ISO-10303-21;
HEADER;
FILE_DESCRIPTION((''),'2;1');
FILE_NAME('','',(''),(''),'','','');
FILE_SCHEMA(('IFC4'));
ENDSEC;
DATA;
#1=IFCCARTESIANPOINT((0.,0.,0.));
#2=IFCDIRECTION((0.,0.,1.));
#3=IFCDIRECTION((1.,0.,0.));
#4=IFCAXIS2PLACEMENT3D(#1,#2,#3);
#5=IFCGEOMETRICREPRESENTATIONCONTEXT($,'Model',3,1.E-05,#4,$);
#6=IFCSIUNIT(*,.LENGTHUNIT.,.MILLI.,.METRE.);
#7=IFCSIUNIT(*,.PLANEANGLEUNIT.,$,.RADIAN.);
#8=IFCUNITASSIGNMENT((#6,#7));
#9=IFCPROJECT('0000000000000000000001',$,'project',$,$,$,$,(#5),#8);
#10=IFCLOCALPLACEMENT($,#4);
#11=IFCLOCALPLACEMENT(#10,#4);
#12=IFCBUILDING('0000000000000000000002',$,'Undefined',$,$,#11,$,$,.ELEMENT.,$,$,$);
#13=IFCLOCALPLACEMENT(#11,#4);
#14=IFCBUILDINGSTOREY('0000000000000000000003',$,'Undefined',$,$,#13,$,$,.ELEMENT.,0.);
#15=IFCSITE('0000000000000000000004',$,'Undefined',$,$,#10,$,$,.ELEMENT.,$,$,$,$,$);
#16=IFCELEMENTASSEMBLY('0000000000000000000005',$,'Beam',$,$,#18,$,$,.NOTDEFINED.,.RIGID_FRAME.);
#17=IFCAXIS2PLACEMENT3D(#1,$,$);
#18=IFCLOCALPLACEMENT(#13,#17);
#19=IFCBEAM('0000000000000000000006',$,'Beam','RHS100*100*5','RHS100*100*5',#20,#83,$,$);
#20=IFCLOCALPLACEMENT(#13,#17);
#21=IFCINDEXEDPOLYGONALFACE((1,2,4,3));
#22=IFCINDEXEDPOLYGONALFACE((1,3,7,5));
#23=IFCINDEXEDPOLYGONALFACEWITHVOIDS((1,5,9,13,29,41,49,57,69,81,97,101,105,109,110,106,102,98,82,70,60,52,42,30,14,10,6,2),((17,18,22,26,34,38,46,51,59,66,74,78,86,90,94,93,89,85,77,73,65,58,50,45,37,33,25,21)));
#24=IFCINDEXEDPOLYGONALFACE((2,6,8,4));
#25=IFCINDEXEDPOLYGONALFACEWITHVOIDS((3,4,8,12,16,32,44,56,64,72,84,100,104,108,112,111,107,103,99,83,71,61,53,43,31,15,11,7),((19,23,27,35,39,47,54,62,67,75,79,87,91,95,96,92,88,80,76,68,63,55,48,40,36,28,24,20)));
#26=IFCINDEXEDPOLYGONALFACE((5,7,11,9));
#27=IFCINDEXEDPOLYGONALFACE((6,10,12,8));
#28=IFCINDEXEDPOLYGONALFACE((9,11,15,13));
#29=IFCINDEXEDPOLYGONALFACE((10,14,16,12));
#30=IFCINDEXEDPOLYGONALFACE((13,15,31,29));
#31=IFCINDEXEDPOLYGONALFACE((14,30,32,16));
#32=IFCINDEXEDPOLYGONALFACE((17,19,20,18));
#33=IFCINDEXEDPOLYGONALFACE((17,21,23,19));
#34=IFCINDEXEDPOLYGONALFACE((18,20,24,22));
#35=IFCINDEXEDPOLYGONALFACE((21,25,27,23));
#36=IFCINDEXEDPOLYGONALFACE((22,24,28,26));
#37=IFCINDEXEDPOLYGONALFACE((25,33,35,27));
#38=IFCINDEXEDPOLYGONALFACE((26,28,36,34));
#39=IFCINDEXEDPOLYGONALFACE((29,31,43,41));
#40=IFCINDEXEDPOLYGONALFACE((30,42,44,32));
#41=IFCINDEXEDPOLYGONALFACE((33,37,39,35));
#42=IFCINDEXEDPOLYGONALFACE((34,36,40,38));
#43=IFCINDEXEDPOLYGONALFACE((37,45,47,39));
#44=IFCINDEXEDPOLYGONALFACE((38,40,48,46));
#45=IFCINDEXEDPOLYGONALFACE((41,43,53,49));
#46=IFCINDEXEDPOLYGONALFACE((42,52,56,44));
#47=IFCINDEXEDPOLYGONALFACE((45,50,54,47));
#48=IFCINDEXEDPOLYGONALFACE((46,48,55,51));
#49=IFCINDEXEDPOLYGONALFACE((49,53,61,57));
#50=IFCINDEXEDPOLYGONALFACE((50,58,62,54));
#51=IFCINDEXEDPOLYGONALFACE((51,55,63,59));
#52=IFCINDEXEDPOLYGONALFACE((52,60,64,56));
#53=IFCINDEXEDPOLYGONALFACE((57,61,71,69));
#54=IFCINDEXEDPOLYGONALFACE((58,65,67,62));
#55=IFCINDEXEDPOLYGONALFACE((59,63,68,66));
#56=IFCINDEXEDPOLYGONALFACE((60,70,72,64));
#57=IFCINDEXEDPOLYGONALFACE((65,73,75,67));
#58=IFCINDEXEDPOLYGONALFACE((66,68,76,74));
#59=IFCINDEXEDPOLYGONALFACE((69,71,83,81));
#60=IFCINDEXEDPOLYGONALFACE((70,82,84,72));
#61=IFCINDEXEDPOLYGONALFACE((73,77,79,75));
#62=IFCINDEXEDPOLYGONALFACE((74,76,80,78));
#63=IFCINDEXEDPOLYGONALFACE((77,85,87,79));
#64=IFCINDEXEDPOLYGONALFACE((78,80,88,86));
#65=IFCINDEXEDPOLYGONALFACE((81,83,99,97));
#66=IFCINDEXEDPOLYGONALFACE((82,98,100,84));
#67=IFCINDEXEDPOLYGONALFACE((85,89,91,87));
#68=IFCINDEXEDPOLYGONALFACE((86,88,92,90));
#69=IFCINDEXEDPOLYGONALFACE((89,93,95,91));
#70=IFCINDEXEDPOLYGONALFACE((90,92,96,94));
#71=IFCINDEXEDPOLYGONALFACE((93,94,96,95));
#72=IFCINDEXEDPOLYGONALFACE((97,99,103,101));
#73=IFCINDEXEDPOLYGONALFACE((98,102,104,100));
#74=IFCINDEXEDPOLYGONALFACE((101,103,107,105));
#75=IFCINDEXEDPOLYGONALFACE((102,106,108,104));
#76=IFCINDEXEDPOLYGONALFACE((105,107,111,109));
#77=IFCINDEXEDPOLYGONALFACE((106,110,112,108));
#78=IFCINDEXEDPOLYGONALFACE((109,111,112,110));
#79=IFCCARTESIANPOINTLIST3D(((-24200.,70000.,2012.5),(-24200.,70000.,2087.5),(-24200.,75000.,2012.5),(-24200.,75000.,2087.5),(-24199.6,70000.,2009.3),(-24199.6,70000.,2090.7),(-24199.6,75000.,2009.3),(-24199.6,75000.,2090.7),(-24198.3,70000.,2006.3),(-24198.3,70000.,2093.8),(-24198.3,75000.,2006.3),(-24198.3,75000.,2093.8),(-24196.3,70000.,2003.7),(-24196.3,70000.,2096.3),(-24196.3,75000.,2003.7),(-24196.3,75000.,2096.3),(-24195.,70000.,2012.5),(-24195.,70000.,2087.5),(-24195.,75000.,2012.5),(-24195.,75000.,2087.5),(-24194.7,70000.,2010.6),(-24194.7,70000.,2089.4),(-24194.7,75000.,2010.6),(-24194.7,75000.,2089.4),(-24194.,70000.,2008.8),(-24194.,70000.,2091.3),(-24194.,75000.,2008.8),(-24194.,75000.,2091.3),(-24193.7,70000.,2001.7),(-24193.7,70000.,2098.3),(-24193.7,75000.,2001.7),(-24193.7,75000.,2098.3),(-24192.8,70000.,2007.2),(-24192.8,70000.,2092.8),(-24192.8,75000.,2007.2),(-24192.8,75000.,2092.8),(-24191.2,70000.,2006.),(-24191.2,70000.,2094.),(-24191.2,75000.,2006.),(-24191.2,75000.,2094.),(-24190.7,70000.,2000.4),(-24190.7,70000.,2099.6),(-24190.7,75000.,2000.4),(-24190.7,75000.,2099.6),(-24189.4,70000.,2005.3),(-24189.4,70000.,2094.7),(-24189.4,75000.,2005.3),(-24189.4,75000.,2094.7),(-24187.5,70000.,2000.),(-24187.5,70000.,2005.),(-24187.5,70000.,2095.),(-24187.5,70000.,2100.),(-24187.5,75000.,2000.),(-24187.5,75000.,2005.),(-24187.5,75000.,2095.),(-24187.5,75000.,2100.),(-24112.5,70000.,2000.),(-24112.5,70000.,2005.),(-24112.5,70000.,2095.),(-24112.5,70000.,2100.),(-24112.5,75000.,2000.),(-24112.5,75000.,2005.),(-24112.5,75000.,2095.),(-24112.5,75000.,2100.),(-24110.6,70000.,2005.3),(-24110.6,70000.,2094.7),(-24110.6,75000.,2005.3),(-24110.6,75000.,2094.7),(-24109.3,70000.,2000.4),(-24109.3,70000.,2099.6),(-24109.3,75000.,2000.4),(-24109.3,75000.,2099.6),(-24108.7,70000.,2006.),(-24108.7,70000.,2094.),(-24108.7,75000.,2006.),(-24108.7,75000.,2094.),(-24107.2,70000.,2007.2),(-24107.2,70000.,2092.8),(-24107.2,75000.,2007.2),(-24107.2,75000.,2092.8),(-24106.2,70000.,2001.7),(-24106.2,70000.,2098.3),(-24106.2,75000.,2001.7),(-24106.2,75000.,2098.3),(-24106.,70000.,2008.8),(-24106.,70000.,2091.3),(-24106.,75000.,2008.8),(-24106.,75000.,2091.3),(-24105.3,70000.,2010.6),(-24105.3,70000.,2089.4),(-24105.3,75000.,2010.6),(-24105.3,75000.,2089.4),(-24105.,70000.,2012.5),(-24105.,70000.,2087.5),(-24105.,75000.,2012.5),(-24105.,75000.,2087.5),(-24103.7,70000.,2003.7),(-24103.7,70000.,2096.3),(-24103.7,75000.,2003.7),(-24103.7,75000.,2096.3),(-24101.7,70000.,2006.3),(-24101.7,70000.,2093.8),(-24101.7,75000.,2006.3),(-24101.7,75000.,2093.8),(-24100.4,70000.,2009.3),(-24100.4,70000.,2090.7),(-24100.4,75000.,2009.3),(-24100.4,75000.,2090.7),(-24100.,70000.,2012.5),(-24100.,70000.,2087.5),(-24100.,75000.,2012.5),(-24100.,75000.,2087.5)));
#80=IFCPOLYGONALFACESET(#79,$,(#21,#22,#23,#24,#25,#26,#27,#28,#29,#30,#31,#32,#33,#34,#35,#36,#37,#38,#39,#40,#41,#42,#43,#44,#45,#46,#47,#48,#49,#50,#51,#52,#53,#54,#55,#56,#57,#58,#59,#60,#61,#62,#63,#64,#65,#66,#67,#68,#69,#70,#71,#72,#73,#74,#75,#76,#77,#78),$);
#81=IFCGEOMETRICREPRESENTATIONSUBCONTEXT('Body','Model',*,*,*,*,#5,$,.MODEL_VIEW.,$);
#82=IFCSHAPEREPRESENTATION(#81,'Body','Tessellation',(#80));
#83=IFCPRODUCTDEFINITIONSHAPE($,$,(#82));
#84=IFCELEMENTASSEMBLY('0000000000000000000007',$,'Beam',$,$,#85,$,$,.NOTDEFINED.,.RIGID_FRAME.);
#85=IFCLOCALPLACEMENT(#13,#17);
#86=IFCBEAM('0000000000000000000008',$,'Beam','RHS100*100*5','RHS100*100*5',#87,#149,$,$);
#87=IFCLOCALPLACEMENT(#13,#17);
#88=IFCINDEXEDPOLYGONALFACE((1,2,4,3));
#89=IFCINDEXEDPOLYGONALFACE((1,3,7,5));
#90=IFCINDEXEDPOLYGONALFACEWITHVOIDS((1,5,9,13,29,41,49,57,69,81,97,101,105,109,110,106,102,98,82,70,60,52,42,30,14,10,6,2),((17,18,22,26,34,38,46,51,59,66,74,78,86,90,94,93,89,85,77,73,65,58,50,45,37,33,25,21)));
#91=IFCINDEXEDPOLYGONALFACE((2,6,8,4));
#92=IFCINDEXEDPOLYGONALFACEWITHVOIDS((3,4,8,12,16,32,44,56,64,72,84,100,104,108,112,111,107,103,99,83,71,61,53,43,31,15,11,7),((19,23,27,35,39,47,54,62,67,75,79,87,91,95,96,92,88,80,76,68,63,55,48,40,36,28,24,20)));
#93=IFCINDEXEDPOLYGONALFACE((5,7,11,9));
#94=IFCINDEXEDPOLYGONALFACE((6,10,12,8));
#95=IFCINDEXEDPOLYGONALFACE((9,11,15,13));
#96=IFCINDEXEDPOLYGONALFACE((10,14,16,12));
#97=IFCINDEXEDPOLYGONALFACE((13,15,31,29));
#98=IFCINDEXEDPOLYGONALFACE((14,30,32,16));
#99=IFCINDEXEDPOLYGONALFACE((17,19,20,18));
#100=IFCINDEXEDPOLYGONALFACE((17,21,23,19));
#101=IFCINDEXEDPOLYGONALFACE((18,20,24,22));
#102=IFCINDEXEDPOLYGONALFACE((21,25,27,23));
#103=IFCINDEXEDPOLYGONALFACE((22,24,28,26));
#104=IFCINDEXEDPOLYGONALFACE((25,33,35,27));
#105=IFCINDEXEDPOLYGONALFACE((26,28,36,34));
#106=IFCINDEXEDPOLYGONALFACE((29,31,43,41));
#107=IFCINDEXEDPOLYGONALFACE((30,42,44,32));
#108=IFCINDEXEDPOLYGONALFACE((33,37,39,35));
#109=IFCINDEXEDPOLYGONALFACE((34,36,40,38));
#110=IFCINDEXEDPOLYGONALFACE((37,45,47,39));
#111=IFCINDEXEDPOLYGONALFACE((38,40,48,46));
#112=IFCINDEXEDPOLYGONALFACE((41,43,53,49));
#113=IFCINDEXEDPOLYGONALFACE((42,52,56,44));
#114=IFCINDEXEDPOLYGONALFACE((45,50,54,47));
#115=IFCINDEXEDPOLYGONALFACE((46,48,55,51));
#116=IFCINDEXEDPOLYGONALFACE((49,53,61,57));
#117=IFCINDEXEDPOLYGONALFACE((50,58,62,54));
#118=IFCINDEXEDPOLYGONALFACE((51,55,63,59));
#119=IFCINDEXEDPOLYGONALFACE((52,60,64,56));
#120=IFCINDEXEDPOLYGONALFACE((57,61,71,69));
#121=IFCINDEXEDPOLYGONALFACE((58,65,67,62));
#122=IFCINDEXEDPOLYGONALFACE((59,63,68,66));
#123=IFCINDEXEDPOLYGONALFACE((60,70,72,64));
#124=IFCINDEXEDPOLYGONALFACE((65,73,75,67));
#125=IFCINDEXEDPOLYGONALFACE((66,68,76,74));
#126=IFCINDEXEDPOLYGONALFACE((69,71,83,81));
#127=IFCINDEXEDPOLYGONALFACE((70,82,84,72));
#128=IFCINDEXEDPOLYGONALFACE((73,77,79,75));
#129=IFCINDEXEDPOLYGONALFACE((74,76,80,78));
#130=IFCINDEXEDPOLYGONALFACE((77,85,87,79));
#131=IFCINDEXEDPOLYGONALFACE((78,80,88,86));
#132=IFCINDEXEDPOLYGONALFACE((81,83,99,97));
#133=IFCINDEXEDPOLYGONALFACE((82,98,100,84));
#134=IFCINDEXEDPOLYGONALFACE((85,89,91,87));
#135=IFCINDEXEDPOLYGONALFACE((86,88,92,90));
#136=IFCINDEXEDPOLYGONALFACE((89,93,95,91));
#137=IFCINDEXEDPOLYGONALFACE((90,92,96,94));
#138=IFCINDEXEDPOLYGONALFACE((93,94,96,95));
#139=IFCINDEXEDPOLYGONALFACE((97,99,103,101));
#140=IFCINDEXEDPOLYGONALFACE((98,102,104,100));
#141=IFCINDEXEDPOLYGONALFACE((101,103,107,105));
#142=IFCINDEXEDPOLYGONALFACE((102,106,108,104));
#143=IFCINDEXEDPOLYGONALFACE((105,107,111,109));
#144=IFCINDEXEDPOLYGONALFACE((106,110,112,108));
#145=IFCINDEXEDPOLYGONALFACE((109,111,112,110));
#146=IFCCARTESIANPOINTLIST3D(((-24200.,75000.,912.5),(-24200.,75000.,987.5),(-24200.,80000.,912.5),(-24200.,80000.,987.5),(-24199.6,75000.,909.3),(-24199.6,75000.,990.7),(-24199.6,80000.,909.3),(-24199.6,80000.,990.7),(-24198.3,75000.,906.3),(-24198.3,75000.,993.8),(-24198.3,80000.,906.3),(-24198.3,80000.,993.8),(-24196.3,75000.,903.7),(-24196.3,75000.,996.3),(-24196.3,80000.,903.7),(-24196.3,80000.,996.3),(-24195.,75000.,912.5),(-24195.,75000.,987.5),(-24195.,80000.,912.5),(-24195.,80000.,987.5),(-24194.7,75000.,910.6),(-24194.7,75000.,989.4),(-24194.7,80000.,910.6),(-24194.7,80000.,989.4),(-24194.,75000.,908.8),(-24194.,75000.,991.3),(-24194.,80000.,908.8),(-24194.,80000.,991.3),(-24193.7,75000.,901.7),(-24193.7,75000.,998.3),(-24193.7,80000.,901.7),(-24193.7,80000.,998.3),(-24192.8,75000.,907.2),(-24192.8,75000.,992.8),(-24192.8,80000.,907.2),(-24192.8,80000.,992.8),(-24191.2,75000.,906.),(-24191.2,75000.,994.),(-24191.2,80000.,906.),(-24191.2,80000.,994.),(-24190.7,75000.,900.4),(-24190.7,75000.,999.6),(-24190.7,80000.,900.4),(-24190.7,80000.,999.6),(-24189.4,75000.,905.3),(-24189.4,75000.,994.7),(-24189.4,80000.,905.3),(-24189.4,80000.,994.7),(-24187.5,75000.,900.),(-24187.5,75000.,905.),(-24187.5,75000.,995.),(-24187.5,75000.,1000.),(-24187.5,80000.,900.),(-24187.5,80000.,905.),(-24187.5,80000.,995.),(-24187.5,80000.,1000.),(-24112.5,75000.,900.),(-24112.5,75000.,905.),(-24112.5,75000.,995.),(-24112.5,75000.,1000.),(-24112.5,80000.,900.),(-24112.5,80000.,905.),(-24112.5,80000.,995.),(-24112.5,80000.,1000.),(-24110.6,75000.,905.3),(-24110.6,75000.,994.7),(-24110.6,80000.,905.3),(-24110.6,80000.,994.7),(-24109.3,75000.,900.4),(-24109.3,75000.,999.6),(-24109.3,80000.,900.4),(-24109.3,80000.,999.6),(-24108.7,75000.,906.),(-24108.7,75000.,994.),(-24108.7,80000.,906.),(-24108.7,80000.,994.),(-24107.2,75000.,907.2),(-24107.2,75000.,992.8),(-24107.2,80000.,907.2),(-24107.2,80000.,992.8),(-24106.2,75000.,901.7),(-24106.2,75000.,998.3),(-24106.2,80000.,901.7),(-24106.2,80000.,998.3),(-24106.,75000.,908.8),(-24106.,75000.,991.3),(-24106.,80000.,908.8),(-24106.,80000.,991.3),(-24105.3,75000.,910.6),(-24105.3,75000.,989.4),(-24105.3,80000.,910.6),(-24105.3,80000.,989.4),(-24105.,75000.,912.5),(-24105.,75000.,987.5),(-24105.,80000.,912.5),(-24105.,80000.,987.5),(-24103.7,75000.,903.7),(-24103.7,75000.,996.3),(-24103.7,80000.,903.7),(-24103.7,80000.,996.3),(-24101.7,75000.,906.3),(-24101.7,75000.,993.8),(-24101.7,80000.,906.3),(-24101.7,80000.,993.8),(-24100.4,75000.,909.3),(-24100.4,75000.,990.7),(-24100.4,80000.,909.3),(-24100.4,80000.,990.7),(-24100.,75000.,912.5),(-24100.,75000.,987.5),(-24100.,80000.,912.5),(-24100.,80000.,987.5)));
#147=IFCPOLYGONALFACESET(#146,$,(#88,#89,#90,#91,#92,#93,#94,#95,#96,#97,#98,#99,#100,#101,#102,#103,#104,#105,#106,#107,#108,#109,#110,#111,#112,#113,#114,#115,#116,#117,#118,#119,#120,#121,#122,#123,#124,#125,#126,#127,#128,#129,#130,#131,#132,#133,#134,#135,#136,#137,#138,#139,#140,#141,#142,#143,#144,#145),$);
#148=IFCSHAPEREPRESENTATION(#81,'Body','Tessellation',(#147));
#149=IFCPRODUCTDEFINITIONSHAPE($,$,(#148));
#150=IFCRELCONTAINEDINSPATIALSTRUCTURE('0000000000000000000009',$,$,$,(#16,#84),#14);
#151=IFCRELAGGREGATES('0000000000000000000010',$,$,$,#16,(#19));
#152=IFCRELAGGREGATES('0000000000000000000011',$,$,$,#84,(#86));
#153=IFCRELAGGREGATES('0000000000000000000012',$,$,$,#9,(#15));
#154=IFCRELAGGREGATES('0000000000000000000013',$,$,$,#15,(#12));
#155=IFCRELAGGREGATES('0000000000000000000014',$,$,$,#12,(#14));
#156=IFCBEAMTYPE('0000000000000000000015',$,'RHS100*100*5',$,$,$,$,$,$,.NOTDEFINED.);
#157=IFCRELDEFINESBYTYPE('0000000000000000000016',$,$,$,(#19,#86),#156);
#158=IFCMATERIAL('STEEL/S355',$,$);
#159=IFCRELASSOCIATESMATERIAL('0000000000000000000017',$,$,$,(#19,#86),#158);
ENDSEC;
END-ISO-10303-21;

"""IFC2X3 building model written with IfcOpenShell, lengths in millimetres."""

from ifc_helpers import new_model, si_unit, frame, origin_with_axes, origin_2d_with_axis, place, context, subcontext, project, spatial, hollow_rectangle, extrude, material, type_object, element, aggregate, save


model = new_model("IFC2X3")

# Units and contexts
model_context = context("Model", 3, precision=1e-05, world=origin_with_axes())
body_context = subcontext(model_context, "Body", "Model", "MODEL_VIEW")
ifc_project = project(units=[si_unit("LENGTHUNIT", "METRE", prefix="MILLI"), si_unit("PLANEANGLEUNIT", "RADIAN")], contexts=[model_context])

# Site, building, storey
site_placement = place(None, origin_with_axes())
site = spatial("IfcSite", under=ifc_project, at=site_placement, Name="Undefined", CompositionType="ELEMENT")
building_placement = place(site_placement, origin_with_axes())
building = spatial("IfcBuilding", under=site, at=building_placement, Name="Undefined", CompositionType="ELEMENT")
storey_placement = place(building_placement, origin_with_axes())
storey = spatial("IfcBuildingStorey", under=building, at=storey_placement, Name="Undefined", CompositionType="ELEMENT", Elevation=0.0)

# Element assemblies, beams
ifc_material_1 = material(Name="STEEL/S355")
beam_type_1 = type_object("IfcBeamType", Name="RHS100*100*5", PredefinedType="NOTDEFINED")
assembly_1_placement = place(storey_placement, origin_with_axes())
assembly_1 = element("IfcElementAssembly", 1, at=assembly_1_placement, inside=storey, Name="Beam", AssemblyPlace="NOTDEFINED", PredefinedType="RIGID_FRAME")
beam_1_placement = place(assembly_1_placement, frame((-24150.0, 70000.0, 2050.0), z_axis=(0.0, 0.0, 1.0), x_axis=(0.0, 1.0, 0.0)))
beam_1 = element("IfcBeam", 2, at=beam_1_placement, type_object=beam_type_1, material=ifc_material_1, Name="Beam", Description="RHS100*100*5", ObjectType="RHS100*100*5", context=body_context, shape_type="SweptSolid", body=[
    extrude(hollow_rectangle(XDim=100.0, YDim=100.0, WallThickness=5.0, InnerFilletRadius=7.5, OuterFilletRadius=12.5, at=origin_2d_with_axis()), frame((5000.0, 0.0, 0.0), z_axis=(-1.0, 0.0, 0.0), x_axis=(0.0, -1.0, 0.0)), (0.0, 0.0, 1.0), 5000.0),
])
aggregate(assembly_1, [beam_1])
assembly_2_placement = place(storey_placement, origin_with_axes())
assembly_2 = element("IfcElementAssembly", 3, at=assembly_2_placement, inside=storey, Name="Beam", AssemblyPlace="NOTDEFINED", PredefinedType="RIGID_FRAME")
beam_2_placement = place(assembly_2_placement, frame((-24150.0, 75000.0, 950.0), z_axis=(0.0, 0.0, 1.0), x_axis=(0.0, 1.0, 0.0)))
beam_2 = element("IfcBeam", 4, at=beam_2_placement, type_object=beam_type_1, material=ifc_material_1, Name="Beam", Description="RHS100*100*5", ObjectType="RHS100*100*5", context=body_context, shape_type="SweptSolid", body=[
    extrude(hollow_rectangle(XDim=100.0, YDim=100.0, WallThickness=5.0, InnerFilletRadius=7.5, OuterFilletRadius=12.5, at=origin_2d_with_axis()), frame((5000.0, 0.0, 0.0), z_axis=(-1.0, 0.0, 0.0), x_axis=(0.0, -1.0, 0.0)), (0.0, 0.0, 1.0), 5000.0),
])
aggregate(assembly_2, [beam_2])

save(model, "model.ifc")
